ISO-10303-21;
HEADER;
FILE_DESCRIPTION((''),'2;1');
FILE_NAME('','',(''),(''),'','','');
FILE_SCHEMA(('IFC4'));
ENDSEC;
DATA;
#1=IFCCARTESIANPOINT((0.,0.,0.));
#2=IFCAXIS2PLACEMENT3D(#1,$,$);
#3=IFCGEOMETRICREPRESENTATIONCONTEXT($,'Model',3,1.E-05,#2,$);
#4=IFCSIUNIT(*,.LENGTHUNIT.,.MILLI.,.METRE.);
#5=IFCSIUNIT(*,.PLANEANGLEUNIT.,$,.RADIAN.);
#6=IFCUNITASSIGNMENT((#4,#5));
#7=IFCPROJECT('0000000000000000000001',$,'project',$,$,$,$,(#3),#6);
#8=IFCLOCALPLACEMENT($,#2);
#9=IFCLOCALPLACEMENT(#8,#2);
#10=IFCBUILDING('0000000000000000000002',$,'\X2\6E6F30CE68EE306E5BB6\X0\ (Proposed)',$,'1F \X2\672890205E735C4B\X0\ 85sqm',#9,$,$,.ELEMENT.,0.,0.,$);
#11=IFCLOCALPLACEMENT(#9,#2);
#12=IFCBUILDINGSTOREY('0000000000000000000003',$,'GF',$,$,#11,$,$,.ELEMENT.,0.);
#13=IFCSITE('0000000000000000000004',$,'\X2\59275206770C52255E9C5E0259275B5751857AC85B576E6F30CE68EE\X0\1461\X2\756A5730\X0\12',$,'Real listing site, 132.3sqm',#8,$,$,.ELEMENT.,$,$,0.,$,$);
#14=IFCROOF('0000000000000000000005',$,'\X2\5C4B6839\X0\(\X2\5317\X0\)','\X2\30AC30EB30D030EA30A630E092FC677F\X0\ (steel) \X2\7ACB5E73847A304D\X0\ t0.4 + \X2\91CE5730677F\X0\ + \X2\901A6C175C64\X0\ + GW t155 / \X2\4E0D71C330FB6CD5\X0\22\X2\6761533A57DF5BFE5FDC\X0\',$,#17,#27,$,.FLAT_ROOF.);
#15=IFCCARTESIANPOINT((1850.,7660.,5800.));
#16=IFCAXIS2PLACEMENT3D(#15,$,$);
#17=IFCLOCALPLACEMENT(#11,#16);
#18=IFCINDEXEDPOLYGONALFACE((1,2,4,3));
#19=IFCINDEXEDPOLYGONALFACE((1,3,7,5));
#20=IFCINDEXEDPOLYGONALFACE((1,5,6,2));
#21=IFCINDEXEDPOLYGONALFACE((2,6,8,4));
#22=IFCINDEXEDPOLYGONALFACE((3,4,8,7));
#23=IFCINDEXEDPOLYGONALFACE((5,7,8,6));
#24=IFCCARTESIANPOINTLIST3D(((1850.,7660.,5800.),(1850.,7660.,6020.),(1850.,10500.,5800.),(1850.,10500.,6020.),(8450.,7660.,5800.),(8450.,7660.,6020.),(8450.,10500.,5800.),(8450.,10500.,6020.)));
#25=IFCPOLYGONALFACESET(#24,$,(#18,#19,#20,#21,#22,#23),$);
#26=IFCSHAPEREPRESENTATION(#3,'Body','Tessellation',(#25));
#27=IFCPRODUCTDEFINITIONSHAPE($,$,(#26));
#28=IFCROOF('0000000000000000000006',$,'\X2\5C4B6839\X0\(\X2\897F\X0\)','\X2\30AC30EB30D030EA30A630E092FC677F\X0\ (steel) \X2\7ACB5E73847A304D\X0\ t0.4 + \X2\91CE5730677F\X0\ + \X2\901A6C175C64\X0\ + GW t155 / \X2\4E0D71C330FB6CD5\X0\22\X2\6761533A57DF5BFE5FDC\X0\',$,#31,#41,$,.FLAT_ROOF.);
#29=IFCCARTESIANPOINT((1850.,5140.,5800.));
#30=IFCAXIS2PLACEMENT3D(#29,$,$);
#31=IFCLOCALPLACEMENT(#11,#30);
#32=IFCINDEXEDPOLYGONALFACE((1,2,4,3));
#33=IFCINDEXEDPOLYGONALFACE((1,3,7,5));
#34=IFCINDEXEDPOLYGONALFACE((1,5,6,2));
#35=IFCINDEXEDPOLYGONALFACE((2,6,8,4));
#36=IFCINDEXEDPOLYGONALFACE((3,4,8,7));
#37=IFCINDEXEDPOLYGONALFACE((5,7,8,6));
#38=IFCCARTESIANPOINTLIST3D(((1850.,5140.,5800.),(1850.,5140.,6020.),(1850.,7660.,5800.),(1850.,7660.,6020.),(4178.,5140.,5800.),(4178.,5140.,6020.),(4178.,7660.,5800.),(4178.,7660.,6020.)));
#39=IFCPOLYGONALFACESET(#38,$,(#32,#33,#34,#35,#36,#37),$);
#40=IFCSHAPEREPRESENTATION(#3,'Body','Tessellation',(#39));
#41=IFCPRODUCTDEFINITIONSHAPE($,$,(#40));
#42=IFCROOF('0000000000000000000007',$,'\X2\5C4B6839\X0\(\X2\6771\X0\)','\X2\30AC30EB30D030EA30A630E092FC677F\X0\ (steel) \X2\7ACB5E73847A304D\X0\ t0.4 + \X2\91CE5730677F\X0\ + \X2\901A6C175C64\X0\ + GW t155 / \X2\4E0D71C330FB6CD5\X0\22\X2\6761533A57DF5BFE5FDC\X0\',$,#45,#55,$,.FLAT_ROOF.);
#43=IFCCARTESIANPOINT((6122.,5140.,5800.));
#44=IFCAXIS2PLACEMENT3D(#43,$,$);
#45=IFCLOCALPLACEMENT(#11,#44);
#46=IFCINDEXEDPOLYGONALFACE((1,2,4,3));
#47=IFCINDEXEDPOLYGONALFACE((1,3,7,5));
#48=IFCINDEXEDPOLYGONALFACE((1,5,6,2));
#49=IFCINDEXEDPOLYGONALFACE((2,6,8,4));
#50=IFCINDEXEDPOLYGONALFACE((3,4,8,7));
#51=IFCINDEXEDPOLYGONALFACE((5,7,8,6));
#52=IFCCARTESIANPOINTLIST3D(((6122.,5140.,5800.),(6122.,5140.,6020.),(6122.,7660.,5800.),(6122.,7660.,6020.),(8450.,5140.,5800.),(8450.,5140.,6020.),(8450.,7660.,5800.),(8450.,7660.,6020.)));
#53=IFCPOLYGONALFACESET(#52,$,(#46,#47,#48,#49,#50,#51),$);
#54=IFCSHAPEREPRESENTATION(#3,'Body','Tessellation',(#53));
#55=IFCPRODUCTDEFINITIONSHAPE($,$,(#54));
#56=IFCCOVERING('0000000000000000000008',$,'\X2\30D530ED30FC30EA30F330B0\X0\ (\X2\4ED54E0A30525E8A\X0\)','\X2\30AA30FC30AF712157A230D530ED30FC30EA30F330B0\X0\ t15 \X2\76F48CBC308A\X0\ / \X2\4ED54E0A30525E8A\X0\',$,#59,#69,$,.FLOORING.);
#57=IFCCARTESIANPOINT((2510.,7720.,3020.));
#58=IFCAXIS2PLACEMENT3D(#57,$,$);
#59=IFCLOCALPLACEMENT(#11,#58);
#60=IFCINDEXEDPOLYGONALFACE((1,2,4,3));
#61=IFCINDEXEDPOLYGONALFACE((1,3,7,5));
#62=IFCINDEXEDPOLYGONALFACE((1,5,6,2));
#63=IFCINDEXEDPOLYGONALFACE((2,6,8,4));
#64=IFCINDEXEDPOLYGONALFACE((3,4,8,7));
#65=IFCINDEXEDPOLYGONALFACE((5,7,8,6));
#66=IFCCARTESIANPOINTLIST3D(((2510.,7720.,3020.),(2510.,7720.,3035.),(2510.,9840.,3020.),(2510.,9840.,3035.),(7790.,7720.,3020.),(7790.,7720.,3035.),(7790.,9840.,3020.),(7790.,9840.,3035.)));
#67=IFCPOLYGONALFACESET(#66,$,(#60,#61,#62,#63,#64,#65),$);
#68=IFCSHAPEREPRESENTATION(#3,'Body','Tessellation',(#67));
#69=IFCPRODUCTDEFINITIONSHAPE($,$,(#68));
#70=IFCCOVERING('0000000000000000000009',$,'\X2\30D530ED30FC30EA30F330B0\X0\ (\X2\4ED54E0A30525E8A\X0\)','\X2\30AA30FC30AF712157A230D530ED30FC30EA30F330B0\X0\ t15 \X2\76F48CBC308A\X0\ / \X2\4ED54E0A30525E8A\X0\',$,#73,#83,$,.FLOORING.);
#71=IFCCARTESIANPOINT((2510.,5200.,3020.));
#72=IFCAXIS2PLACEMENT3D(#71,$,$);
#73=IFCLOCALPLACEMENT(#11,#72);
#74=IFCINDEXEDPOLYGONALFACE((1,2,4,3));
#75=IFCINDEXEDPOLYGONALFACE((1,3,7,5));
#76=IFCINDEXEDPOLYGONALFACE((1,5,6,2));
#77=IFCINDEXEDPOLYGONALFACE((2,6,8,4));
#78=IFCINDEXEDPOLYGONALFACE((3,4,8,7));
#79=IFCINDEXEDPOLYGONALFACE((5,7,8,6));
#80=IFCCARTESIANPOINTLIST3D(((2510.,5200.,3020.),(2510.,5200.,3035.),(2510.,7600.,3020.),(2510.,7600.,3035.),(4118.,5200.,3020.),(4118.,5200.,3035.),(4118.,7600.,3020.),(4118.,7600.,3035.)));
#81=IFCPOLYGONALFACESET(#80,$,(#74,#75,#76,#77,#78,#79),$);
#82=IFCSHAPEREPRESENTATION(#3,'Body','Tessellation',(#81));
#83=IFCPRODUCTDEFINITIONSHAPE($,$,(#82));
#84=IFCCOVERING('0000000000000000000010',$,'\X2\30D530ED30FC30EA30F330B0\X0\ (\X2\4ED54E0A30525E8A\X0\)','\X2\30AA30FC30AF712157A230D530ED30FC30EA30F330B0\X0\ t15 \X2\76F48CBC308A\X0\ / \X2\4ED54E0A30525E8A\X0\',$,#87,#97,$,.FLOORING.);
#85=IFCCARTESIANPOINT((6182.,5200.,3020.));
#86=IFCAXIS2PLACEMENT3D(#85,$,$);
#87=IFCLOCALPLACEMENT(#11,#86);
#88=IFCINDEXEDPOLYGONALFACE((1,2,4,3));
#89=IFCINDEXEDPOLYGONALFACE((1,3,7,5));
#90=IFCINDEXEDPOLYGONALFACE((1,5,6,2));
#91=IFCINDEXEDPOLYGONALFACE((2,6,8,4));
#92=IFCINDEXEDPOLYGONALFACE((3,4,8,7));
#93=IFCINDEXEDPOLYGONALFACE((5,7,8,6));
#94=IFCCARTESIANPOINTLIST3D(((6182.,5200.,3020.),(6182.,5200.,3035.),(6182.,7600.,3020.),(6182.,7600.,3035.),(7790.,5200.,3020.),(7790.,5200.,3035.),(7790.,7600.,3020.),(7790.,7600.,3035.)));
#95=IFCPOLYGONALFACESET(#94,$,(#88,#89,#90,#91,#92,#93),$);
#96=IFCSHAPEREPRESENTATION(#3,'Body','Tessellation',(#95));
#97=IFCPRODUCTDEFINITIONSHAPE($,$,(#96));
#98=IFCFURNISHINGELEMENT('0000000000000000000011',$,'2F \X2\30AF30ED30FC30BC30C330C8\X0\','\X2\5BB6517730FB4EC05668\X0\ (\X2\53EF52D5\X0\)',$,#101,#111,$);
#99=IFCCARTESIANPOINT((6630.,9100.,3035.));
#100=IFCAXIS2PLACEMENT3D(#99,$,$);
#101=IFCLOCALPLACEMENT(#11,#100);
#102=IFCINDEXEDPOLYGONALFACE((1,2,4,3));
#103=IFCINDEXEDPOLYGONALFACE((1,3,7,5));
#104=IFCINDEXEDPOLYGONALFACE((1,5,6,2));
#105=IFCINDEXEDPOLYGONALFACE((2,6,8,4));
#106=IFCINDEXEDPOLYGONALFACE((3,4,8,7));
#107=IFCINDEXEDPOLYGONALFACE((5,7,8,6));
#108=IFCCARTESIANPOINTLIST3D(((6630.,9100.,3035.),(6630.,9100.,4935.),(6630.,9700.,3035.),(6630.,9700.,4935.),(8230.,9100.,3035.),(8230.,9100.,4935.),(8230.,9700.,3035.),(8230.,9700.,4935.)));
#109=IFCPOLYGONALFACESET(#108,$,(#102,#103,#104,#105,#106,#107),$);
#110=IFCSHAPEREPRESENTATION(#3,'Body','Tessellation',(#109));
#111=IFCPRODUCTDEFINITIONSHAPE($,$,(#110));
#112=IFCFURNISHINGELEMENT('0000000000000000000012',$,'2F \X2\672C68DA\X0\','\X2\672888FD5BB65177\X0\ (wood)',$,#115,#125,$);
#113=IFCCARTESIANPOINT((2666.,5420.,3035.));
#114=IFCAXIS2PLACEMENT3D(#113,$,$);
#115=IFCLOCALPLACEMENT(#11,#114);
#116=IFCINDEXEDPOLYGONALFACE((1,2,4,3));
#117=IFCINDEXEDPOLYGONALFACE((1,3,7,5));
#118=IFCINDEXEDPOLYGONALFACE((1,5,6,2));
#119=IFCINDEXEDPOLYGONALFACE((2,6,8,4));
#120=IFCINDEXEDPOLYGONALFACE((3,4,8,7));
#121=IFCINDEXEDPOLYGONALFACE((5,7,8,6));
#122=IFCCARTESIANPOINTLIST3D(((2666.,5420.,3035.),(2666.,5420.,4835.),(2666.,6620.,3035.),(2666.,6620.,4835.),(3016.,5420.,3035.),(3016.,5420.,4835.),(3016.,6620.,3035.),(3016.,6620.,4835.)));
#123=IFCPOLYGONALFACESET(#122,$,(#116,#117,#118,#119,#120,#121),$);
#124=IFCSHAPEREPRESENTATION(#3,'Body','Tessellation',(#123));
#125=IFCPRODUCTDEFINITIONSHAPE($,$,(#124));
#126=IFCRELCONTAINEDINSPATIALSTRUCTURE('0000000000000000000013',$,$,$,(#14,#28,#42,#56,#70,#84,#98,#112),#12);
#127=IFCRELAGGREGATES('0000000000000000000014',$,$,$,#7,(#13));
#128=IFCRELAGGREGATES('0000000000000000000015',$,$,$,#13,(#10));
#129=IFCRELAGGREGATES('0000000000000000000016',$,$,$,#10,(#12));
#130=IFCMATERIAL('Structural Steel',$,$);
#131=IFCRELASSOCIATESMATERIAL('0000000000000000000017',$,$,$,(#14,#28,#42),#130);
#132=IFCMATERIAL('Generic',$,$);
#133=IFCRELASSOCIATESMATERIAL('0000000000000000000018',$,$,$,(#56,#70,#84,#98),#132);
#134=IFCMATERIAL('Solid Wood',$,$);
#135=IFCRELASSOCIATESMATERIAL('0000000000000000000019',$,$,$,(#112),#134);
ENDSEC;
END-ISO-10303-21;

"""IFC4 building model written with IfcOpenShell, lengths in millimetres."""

from ifc_helpers import new_model, si_unit, frame, frame_2d, origin, place, context, project, spatial, rectangle, extrude, material, element, save


model = new_model("IFC4")

# Units and contexts
model_context = context("Model", 3, precision=1e-05, world=origin())
ifc_project = project(units=[si_unit("LENGTHUNIT", "METRE", prefix="MILLI"), si_unit("PLANEANGLEUNIT", "RADIAN")], contexts=[model_context])

# Site, building, storey
site_placement = place(None, origin())
site = spatial("IfcSite", under=ifc_project, at=site_placement, Name="大分県別府市大字内竈字湯ノ森1461番地12", ObjectType="Real listing site, 132.3sqm", CompositionType="ELEMENT", RefElevation=0.0)
building_placement = place(site_placement, origin())
building = spatial("IfcBuilding", under=site, at=building_placement, Name="湯ノ森の家 (Proposed)", ObjectType="1F 木造平屋 85sqm", CompositionType="ELEMENT", ElevationOfRefHeight=0.0, ElevationOfTerrain=0.0)
storey_placement = place(building_placement, origin())
storey = spatial("IfcBuildingStorey", under=building, at=storey_placement, Name="GF", CompositionType="ELEMENT", Elevation=0.0)

# Shared definitions
ifc_material_1 = material(Name="Solid Wood")

# Shared definitions
ifc_material_2 = material(Name="Generic")

# Roofs
ifc_material_3 = material(Name="Structural Steel")
for number, where, name in (
    (1, (1850.0, 7660.0, 5800.0), "屋根(北)"),
):
    element("IfcRoof", number, at=place(storey_placement, frame(where)), inside=storey, material=ifc_material_3, Name=name, Description="ガルバリウム鋼板 (steel) 立平葺き t0.4 + 野地板 + 通気層 + GW t155 / 不燃・法22条区域対応", PredefinedType="FLAT_ROOF", context=model_context, shape_type="SweptSolid", body=[
        extrude(rectangle(XDim=6600.0, YDim=2840.0, at=frame_2d((3300.0, 1420.0))), frame((1850.0, 7660.0, 5800.0)), (0.0, 0.0, 1.0), 220.0),
    ])
roof_1_placement = place(storey_placement, frame((1850.0, 5140.0, 5800.0)))
element("IfcRoof", 2, at=roof_1_placement, inside=storey, material=ifc_material_3, Name="屋根(西)", Description="ガルバリウム鋼板 (steel) 立平葺き t0.4 + 野地板 + 通気層 + GW t155 / 不燃・法22条区域対応", PredefinedType="FLAT_ROOF", context=model_context, shape_type="SweptSolid", body=[
    extrude(rectangle(XDim=2328.0, YDim=2520.0, at=frame_2d((1164.0, 1260.0))), frame((1850.0, 5140.0, 5800.0)), (0.0, 0.0, 1.0), 220.0),
])
roof_2_placement = place(storey_placement, frame((6122.0, 5140.0, 5800.0)))
element("IfcRoof", 3, at=roof_2_placement, inside=storey, material=ifc_material_3, Name="屋根(東)", Description="ガルバリウム鋼板 (steel) 立平葺き t0.4 + 野地板 + 通気層 + GW t155 / 不燃・法22条区域対応", PredefinedType="FLAT_ROOF", context=model_context, shape_type="SweptSolid", body=[
    extrude(rectangle(XDim=2328.0, YDim=2520.0, at=frame_2d((1164.0, 1260.0))), frame((6122.0, 5140.0, 5800.0)), (0.0, 0.0, 1.0), 220.0),
])

# Coverings
covering_1_placement = place(storey_placement, frame((2510.0, 7720.0, 3020.0)))
element("IfcCovering", 4, at=covering_1_placement, inside=storey, material=ifc_material_2, Name="フローリング (仕上げ床)", Description="オーク無垢フローリング t15 直貼り / 仕上げ床", PredefinedType="FLOORING", context=model_context, shape_type="SweptSolid", body=[
    extrude(rectangle(XDim=5280.0, YDim=2120.0, at=frame_2d((2640.0, 1060.0))), frame((2510.0, 7720.0, 3020.0)), (0.0, 0.0, 1.0), 15.0),
])
covering_2_placement = place(storey_placement, frame((2510.0, 5200.0, 3020.0)))
element("IfcCovering", 5, at=covering_2_placement, inside=storey, material=ifc_material_2, Name="フローリング (仕上げ床)", Description="オーク無垢フローリング t15 直貼り / 仕上げ床", PredefinedType="FLOORING", context=model_context, shape_type="SweptSolid", body=[
    extrude(rectangle(XDim=1608.0, YDim=2400.0, at=frame_2d((804.0, 1200.0))), frame((2510.0, 5200.0, 3020.0)), (0.0, 0.0, 1.0), 15.0),
])
covering_3_placement = place(storey_placement, frame((6182.0, 5200.0, 3020.0)))
element("IfcCovering", 6, at=covering_3_placement, inside=storey, material=ifc_material_2, Name="フローリング (仕上げ床)", Description="オーク無垢フローリング t15 直貼り / 仕上げ床", PredefinedType="FLOORING", context=model_context, shape_type="SweptSolid", body=[
    extrude(rectangle(XDim=1608.0, YDim=2400.0, at=frame_2d((804.0, 1200.0))), frame((6182.0, 5200.0, 3020.0)), (0.0, 0.0, 1.0), 15.0),
])

# Furnishing elements
furnishing_1_placement = place(storey_placement, frame((6630.0, 9100.0, 3035.0)))
element("IfcFurnishingElement", 7, at=furnishing_1_placement, inside=storey, material=ifc_material_2, Name="2F クローゼット", Description="家具・什器 (可動)", context=model_context, shape_type="SweptSolid", body=[
    extrude(rectangle(XDim=1600.0, YDim=600.0, at=frame_2d((800.0, 300.0))), frame((6630.0, 9100.0, 3035.0)), (0.0, 0.0, 1.0), 1900.0),
])
furnishing_2_placement = place(storey_placement, frame((2666.0, 5420.0, 3035.0)))
element("IfcFurnishingElement", 8, at=furnishing_2_placement, inside=storey, material=ifc_material_1, Name="2F 本棚", Description="木製家具 (wood)", context=model_context, shape_type="SweptSolid", body=[
    extrude(rectangle(XDim=350.0, YDim=1200.0, at=frame_2d((175.0, 600.0))), frame((2666.0, 5420.0, 3035.0)), (0.0, 0.0, 1.0), 1800.0),
])

save(model, "model.ifc")
